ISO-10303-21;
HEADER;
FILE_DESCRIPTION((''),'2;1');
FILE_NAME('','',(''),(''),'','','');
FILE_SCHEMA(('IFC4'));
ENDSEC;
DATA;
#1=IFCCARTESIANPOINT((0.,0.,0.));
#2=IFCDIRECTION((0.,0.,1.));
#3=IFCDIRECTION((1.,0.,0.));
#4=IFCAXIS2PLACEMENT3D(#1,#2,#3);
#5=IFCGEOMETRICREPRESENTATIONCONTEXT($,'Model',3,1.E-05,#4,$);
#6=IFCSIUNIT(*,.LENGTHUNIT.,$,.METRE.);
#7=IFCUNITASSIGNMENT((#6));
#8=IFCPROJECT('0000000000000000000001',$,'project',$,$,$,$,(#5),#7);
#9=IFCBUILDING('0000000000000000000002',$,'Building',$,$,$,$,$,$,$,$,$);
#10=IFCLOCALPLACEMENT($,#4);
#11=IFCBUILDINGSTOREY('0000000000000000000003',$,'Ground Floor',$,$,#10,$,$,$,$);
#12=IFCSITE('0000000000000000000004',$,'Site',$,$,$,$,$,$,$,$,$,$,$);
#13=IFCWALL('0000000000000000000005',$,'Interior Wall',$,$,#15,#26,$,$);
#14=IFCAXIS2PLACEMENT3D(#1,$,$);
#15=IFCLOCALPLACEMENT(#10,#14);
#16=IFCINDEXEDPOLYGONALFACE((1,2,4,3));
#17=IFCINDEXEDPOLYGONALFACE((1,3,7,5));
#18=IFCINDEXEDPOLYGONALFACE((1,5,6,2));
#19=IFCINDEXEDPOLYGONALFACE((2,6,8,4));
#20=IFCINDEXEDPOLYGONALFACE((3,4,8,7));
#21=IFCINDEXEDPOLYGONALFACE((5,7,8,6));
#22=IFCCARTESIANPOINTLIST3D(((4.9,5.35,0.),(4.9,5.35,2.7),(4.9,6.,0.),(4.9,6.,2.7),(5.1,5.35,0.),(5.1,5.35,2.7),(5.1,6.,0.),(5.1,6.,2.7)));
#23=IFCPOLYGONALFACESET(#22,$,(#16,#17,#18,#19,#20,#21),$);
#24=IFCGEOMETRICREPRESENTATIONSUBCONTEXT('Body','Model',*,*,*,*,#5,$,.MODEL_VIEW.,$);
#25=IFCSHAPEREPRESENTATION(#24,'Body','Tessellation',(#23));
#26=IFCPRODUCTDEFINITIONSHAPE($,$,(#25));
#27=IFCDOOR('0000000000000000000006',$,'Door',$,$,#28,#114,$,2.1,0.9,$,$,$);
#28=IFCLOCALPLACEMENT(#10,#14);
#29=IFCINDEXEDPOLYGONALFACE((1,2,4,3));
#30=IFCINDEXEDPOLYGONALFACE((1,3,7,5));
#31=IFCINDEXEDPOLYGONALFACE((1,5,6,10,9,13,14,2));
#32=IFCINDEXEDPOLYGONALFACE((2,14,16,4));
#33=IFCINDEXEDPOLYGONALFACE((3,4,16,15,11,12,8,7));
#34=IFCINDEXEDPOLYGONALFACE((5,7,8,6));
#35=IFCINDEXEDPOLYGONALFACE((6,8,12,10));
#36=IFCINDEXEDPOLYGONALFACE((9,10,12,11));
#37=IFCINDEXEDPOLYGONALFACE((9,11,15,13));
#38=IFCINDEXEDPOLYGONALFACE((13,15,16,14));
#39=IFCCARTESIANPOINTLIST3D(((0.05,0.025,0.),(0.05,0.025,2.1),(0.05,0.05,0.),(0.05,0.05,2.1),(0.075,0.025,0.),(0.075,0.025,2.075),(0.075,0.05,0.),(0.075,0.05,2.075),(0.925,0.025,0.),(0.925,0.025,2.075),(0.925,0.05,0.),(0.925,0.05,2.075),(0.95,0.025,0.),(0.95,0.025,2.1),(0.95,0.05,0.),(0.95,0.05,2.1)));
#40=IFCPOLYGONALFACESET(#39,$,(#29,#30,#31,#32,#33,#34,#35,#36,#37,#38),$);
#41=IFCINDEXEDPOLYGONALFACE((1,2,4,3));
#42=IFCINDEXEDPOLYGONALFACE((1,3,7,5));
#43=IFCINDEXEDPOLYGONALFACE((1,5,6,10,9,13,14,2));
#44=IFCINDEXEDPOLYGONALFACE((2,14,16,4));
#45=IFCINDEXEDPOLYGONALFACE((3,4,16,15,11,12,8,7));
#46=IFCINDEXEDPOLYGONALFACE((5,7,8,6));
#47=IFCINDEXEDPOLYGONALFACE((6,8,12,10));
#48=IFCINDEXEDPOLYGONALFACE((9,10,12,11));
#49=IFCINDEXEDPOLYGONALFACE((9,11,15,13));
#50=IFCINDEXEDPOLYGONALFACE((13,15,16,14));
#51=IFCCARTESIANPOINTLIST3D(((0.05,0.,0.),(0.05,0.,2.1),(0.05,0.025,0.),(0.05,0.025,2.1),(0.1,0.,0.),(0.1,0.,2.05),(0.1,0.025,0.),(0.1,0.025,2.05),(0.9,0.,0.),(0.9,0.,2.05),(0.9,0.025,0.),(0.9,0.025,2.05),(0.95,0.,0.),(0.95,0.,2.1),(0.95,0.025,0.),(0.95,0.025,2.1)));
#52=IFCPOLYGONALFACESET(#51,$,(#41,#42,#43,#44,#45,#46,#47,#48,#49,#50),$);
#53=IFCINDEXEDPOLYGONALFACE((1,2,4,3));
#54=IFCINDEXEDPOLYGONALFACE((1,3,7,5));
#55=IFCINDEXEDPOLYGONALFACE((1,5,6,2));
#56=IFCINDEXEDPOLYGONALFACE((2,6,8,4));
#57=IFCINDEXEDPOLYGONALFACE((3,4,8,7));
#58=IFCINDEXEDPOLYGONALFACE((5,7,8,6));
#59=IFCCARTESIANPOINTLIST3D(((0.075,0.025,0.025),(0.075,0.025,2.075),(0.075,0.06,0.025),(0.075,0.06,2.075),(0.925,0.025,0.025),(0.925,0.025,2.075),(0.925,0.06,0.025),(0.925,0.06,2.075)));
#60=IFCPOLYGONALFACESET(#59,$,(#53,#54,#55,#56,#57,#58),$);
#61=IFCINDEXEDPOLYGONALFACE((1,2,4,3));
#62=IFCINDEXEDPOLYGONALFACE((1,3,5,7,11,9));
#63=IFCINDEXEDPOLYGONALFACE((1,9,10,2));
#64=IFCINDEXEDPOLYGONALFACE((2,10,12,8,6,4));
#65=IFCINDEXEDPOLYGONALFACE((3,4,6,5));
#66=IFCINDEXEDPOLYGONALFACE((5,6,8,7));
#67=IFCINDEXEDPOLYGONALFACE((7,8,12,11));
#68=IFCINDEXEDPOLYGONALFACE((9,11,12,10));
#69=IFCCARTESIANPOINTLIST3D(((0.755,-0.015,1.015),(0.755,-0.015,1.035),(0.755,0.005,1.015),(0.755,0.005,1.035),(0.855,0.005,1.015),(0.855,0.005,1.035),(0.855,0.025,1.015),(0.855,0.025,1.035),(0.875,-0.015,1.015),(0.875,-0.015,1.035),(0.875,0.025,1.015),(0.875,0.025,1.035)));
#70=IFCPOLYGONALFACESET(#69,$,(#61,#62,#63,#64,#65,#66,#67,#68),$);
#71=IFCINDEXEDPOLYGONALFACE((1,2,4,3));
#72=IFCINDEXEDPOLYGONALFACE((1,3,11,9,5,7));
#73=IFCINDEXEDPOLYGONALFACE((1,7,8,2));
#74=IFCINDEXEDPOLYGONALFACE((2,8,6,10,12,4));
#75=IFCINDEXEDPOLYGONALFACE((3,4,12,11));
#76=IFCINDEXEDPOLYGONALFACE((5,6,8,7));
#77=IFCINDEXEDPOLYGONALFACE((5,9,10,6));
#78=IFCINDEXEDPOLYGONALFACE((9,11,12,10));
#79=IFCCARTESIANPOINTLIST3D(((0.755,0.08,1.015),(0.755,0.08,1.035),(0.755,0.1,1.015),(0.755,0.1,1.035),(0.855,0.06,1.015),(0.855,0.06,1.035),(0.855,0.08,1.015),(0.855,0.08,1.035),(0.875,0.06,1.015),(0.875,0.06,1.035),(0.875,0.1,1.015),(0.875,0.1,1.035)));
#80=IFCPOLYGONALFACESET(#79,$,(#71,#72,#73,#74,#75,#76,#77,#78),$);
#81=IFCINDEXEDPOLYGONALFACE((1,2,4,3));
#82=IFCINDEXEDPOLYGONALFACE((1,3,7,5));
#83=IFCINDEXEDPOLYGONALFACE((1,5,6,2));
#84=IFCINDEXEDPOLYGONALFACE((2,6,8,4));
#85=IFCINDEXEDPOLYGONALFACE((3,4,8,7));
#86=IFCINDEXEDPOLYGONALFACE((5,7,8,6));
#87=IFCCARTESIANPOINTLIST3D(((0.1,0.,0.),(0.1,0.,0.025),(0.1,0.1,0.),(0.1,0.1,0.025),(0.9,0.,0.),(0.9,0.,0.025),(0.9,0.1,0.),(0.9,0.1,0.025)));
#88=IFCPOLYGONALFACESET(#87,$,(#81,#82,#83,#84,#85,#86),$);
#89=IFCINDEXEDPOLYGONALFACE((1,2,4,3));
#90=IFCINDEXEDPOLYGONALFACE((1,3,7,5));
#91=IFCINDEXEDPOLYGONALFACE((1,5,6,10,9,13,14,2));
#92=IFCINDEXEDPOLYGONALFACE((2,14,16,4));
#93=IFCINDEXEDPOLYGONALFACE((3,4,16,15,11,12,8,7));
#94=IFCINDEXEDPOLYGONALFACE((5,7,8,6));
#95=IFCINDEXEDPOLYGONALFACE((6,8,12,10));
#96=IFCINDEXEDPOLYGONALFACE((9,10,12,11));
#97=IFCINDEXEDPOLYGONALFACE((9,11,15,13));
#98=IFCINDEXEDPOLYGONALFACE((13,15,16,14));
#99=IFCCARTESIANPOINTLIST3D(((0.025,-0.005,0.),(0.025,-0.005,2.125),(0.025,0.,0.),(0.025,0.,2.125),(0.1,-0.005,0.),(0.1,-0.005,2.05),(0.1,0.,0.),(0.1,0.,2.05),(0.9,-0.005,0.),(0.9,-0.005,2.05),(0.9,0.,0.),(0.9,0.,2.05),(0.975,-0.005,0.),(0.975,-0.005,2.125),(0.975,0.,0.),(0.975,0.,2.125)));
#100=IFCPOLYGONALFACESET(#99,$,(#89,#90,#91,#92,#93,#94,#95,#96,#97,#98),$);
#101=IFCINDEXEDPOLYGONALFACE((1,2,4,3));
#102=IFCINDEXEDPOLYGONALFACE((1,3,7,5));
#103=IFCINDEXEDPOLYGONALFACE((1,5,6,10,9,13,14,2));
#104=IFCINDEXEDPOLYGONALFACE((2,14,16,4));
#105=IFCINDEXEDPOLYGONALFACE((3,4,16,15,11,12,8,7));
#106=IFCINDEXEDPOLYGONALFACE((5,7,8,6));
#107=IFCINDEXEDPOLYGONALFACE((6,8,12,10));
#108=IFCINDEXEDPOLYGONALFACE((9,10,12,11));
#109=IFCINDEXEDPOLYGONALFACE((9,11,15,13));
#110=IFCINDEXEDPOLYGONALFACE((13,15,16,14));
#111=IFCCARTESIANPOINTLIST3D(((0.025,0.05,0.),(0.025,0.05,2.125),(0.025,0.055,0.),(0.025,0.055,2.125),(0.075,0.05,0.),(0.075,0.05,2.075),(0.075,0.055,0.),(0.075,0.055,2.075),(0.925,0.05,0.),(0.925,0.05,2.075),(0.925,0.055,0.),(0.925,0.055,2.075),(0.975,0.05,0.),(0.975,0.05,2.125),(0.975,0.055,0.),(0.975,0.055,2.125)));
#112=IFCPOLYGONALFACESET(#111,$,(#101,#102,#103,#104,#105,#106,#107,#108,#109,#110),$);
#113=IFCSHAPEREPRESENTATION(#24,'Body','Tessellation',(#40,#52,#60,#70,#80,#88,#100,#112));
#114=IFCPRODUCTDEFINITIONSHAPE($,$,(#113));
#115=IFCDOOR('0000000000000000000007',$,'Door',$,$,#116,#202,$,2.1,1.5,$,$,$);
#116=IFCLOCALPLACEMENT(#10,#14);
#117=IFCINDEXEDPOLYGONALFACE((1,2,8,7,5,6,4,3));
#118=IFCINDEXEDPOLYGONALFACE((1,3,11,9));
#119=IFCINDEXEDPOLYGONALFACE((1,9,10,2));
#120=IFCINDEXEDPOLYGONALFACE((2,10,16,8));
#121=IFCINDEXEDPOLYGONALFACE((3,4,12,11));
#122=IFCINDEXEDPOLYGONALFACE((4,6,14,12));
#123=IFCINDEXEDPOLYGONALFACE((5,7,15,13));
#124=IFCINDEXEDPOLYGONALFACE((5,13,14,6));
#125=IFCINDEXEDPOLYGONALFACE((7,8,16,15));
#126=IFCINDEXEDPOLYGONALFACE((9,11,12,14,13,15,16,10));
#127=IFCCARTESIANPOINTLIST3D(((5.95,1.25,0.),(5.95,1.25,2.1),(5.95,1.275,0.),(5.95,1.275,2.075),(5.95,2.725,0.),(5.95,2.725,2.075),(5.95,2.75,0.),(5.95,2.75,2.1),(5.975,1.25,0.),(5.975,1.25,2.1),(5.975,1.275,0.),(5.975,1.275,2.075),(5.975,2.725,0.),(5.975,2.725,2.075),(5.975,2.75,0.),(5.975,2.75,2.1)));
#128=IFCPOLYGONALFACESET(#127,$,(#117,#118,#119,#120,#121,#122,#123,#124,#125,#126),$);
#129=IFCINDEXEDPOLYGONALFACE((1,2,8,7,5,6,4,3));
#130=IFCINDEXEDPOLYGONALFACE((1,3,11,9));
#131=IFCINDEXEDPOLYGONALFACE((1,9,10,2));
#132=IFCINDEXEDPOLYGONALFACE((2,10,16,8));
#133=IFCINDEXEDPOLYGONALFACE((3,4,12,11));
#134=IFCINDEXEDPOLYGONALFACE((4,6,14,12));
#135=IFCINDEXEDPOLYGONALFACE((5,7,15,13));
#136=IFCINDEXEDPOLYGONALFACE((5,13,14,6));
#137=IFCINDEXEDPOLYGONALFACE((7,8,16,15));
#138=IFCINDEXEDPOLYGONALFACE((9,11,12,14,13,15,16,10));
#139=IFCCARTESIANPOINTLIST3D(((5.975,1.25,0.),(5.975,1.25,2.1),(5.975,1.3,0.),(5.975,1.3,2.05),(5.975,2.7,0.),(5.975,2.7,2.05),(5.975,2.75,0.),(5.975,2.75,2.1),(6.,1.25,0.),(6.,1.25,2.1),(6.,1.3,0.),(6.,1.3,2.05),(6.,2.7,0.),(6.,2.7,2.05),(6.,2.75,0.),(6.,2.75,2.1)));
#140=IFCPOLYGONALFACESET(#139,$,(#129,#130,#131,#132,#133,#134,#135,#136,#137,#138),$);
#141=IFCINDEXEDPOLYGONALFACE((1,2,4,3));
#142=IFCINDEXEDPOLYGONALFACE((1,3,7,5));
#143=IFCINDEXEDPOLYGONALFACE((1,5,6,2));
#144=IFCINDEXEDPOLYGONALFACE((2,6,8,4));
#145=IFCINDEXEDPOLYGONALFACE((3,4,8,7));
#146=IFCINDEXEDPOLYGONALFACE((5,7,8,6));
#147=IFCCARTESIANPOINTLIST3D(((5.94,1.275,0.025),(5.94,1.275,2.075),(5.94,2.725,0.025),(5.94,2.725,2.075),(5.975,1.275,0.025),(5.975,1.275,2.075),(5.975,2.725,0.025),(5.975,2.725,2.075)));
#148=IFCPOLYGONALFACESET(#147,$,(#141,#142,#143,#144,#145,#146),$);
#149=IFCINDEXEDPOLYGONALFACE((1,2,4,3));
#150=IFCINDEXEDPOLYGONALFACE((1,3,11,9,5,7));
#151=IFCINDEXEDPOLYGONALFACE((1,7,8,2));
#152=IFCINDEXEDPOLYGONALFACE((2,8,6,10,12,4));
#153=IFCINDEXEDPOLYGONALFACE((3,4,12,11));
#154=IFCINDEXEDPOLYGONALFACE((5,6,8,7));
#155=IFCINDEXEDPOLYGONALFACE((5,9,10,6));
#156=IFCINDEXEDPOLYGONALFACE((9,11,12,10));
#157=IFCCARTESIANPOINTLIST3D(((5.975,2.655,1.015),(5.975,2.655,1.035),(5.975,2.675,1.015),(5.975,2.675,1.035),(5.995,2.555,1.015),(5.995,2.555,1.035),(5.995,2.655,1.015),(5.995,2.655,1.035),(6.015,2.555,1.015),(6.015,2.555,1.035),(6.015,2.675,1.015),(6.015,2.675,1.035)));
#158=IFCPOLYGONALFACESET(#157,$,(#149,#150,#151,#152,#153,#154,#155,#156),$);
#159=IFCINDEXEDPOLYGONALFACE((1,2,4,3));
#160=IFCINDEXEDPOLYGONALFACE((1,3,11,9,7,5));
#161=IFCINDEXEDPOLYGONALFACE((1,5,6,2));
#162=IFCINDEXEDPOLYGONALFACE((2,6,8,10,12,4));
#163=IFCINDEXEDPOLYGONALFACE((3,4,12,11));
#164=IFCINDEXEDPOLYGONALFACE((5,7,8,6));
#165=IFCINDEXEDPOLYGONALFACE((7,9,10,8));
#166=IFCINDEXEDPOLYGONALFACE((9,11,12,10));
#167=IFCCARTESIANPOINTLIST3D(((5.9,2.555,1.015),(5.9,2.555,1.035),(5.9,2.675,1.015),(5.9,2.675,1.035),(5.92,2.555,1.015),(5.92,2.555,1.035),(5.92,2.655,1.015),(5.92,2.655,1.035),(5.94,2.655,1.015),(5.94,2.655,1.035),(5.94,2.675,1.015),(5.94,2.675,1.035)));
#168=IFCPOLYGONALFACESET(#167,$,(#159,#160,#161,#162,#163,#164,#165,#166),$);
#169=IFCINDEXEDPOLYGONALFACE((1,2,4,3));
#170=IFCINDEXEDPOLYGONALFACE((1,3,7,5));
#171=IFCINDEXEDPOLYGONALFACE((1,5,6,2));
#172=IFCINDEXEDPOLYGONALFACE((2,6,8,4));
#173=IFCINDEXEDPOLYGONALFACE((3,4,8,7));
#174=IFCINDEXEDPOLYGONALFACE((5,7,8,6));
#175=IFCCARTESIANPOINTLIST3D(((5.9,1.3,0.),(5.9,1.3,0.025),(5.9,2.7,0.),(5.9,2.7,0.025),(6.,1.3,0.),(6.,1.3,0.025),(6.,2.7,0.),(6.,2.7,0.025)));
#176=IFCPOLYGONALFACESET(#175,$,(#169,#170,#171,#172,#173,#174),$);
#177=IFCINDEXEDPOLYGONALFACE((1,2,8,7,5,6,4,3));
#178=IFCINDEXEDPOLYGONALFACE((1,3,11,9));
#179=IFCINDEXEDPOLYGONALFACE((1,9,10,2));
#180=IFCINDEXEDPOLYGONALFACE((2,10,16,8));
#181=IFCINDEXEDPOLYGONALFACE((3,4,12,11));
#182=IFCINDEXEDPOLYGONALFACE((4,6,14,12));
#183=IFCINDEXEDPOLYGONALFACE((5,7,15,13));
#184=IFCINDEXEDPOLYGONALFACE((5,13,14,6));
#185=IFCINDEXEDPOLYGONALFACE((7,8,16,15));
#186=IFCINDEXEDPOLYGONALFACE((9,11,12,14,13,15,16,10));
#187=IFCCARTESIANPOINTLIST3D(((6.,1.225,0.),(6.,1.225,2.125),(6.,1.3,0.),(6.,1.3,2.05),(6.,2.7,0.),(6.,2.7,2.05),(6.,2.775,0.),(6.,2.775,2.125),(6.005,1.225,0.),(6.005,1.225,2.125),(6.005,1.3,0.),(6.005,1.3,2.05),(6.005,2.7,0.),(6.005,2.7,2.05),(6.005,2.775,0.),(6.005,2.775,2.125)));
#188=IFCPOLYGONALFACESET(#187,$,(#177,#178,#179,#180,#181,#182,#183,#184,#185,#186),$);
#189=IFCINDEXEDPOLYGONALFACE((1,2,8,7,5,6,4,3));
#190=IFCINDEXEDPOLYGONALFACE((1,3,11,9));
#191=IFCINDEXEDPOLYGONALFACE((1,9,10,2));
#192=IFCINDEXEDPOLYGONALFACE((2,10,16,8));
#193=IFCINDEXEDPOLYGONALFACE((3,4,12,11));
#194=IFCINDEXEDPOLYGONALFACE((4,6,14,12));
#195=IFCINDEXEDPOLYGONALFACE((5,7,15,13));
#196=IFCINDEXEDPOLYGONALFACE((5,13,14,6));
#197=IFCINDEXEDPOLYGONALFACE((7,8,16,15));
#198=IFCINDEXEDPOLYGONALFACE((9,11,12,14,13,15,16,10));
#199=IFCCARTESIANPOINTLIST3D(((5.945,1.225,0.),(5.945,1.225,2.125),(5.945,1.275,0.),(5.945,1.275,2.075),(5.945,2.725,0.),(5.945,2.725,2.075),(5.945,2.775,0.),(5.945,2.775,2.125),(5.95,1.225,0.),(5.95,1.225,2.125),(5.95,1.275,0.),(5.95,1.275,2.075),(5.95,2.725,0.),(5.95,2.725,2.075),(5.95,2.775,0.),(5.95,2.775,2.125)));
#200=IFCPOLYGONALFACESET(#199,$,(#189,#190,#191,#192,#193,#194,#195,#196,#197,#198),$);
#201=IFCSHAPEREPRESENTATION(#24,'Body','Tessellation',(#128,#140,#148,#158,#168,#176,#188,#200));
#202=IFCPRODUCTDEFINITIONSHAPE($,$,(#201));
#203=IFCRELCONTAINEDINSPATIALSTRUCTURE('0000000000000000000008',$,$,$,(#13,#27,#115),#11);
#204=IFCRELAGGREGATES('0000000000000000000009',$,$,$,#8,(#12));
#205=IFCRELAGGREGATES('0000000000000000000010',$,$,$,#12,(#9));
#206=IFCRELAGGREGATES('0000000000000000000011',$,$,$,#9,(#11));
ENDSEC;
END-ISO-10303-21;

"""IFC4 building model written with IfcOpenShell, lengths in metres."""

from ifc_helpers import new_model, si_unit, frame, origin_with_axes, place, context, subcontext, project, spatial, line, indexed_curve, outline, extrude, element, save


model = new_model("IFC4")

# Units and contexts
model_context = context("Model", 3, precision=1e-05, world=origin_with_axes())
body_context = subcontext(model_context, "Body", "Model", "MODEL_VIEW")
ifc_project = project(units=[si_unit("LENGTHUNIT", "METRE")], contexts=[model_context])

# Site, building, storey
site = spatial("IfcSite", under=ifc_project, Name="Site")
building = spatial("IfcBuilding", under=site, Name="Building")
storey_placement = place(None, origin_with_axes())
storey = spatial("IfcBuildingStorey", under=building, at=storey_placement, Name="Ground Floor")

# Wall
for number, where, z_axis, x_axis, name in (
    (1, (5.0, 5.35, 0.0), (0.0, 0.0, 1.0), (0.0, 1.0, 0.0), "Interior Wall"),
):
    element("IfcWall", number, at=place(storey_placement, frame(where, z_axis=z_axis, x_axis=x_axis)), inside=storey, Name=name, context=body_context, shape_type="SweptSolid", body=[
        extrude(outline(indexed_curve([(0.0, 0.0), (0.0, 0.2), (0.65, 0.2), (0.65, 0.0), (0.0, 0.0)], self_intersect=False)), frame((0.0, -0.1, 0.0), z_axis=(0.0, 0.0, 1.0), x_axis=(1.0, 0.0, 0.0)), (0.0, 0.0, 1.0), 2.7),
    ])

# Doors
door_1_placement = place(storey_placement, frame((0.05, 0.0, 0.0), z_axis=(0.0, 0.0, 1.0), x_axis=(1.0, 0.0, 0.0)))
element("IfcDoor", 2, at=door_1_placement, inside=storey, Name="Door", OverallHeight=2.1, OverallWidth=0.9, context=body_context, shape_type="SweptSolid", body=[
    extrude(outline(indexed_curve([(0.0, 0.0), (0.0, 2.1), (0.9, 2.1), (0.9, 0.0), (0.875, 0.0), (0.875, 2.075), (0.025, 2.075), (0.025, 0.0)], segments=[line(1, 2, 3, 4, 5, 6, 7, 8, 1)])), frame((0.0, 0.025, 0.0), z_axis=(0.0, -1.0, 0.0), x_axis=(1.0, 0.0, 0.0)), (0.0, 0.0, -1.0), 0.025),
    extrude(outline(indexed_curve([(0.0, 0.0), (0.0, 2.1), (0.9, 2.1), (0.9, 0.0), (0.85, 0.0), (0.85, 2.05), (0.05, 2.05), (0.05, 0.0)], segments=[line(1, 2, 3, 4, 5, 6, 7, 8, 1)])), frame((0.0, 0.0, 0.0), z_axis=(0.0, -1.0, 0.0), x_axis=(1.0, 0.0, 0.0)), (0.0, 0.0, -1.0), 0.025),
    extrude(outline(indexed_curve([(0.0, 0.0), (0.85, 0.0), (0.85, 0.035), (0.0, 0.035)], segments=[line(1, 2, 3, 4, 1)])), frame((0.025, 0.025, 0.025), z_axis=(0.0, 0.0, 1.0), x_axis=(1.0, 0.0, 0.0)), (0.0, 0.0, 1.0), 2.05),
    extrude(outline(indexed_curve([(0.0, 0.0), (0.0, -0.04), (-0.12, -0.04), (-0.12, -0.02), (-0.02, -0.02), (-0.02, 0.0)], segments=[line(1, 2, 3, 4, 5, 6, 1)])), frame((0.825, 0.025, 1.015), z_axis=(0.0, 0.0, 1.0), x_axis=(1.0, 0.0, 0.0)), (0.0, 0.0, 1.0), 0.02),
    extrude(outline(indexed_curve([(0.0, 0.0), (0.0, 0.04), (-0.12, 0.04), (-0.12, 0.02), (-0.02, 0.02), (-0.02, 0.0)], segments=[line(1, 2, 3, 4, 5, 6, 1)])), frame((0.825, 0.06, 1.015), z_axis=(0.0, 0.0, 1.0), x_axis=(1.0, 0.0, 0.0)), (0.0, 0.0, 1.0), 0.02),
    extrude(outline(indexed_curve([(0.0, 0.0), (0.8, 0.0), (0.8, 0.1), (0.0, 0.1)], segments=[line(1, 2, 3, 4, 1)])), frame((0.05, 0.0, 0.0), z_axis=(0.0, 0.0, 1.0), x_axis=(1.0, 0.0, 0.0)), (0.0, 0.0, 1.0), 0.025),
    extrude(outline(indexed_curve([(0.0, 0.0), (0.0, 2.125), (0.95, 2.125), (0.95, 0.0), (0.875, 0.0), (0.875, 2.05), (0.075, 2.05), (0.075, 0.0)], segments=[line(1, 2, 3, 4, 5, 6, 7, 8, 1)])), frame((-0.025, -0.005, 0.0), z_axis=(0.0, -1.0, 0.0), x_axis=(1.0, 0.0, 0.0)), (0.0, 0.0, -1.0), 0.005),
    extrude(outline(indexed_curve([(0.0, 0.0), (0.0, 2.125), (0.95, 2.125), (0.95, 0.0), (0.9, 0.0), (0.9, 2.075), (0.05, 2.075), (0.05, 0.0)], segments=[line(1, 2, 3, 4, 5, 6, 7, 8, 1)])), frame((-0.025, 0.05, 0.0), z_axis=(0.0, -1.0, 0.0), x_axis=(1.0, 0.0, 0.0)), (0.0, 0.0, -1.0), 0.005),
])
door_2_placement = place(storey_placement, frame((6.0, 1.25, 0.0), z_axis=(0.0, 0.0, 1.0), x_axis=(0.0, 1.0, 0.0)))
element("IfcDoor", 3, at=door_2_placement, inside=storey, Name="Door", OverallHeight=2.1, OverallWidth=1.5, context=body_context, shape_type="SweptSolid", body=[
    extrude(outline(indexed_curve([(0.0, 0.0), (0.0, 2.1), (1.5, 2.1), (1.5, 0.0), (1.475, 0.0), (1.475, 2.075), (0.025, 2.075), (0.025, 0.0)], segments=[line(1, 2, 3, 4, 5, 6, 7, 8, 1)])), frame((0.0, 0.025, 0.0), z_axis=(0.0, -1.0, 0.0), x_axis=(1.0, 0.0, 0.0)), (0.0, 0.0, -1.0), 0.025),
    extrude(outline(indexed_curve([(0.0, 0.0), (0.0, 2.1), (1.5, 2.1), (1.5, 0.0), (1.45, 0.0), (1.45, 2.05), (0.05, 2.05), (0.05, 0.0)], segments=[line(1, 2, 3, 4, 5, 6, 7, 8, 1)])), frame((0.0, 0.0, 0.0), z_axis=(0.0, -1.0, 0.0), x_axis=(1.0, 0.0, 0.0)), (0.0, 0.0, -1.0), 0.025),
    extrude(outline(indexed_curve([(0.0, 0.0), (1.45, 0.0), (1.45, 0.035), (0.0, 0.035)], segments=[line(1, 2, 3, 4, 1)])), frame((0.025, 0.025, 0.025), z_axis=(0.0, 0.0, 1.0), x_axis=(1.0, 0.0, 0.0)), (0.0, 0.0, 1.0), 2.05),
    extrude(outline(indexed_curve([(0.0, 0.0), (0.0, -0.04), (-0.12, -0.04), (-0.12, -0.02), (-0.02, -0.02), (-0.02, 0.0)], segments=[line(1, 2, 3, 4, 5, 6, 1)])), frame((1.425, 0.025, 1.015), z_axis=(0.0, 0.0, 1.0), x_axis=(1.0, 0.0, 0.0)), (0.0, 0.0, 1.0), 0.02),
    extrude(outline(indexed_curve([(0.0, 0.0), (0.0, 0.04), (-0.12, 0.04), (-0.12, 0.02), (-0.02, 0.02), (-0.02, 0.0)], segments=[line(1, 2, 3, 4, 5, 6, 1)])), frame((1.425, 0.06, 1.015), z_axis=(0.0, 0.0, 1.0), x_axis=(1.0, 0.0, 0.0)), (0.0, 0.0, 1.0), 0.02),
    extrude(outline(indexed_curve([(0.0, 0.0), (1.4, 0.0), (1.4, 0.1), (0.0, 0.1)], segments=[line(1, 2, 3, 4, 1)])), frame((0.05, 0.0, 0.0), z_axis=(0.0, 0.0, 1.0), x_axis=(1.0, 0.0, 0.0)), (0.0, 0.0, 1.0), 0.025),
    extrude(outline(indexed_curve([(0.0, 0.0), (0.0, 2.125), (1.55, 2.125), (1.55, 0.0), (1.475, 0.0), (1.475, 2.05), (0.075, 2.05), (0.075, 0.0)], segments=[line(1, 2, 3, 4, 5, 6, 7, 8, 1)])), frame((-0.025, -0.005, 0.0), z_axis=(0.0, -1.0, 0.0), x_axis=(1.0, 0.0, 0.0)), (0.0, 0.0, -1.0), 0.005),
    extrude(outline(indexed_curve([(0.0, 0.0), (0.0, 2.125), (1.55, 2.125), (1.55, 0.0), (1.5, 0.0), (1.5, 2.075), (0.05, 2.075), (0.05, 0.0)], segments=[line(1, 2, 3, 4, 5, 6, 7, 8, 1)])), frame((-0.025, 0.05, 0.0), z_axis=(0.0, -1.0, 0.0), x_axis=(1.0, 0.0, 0.0)), (0.0, 0.0, -1.0), 0.005),
])

save(model, "model.ifc")
